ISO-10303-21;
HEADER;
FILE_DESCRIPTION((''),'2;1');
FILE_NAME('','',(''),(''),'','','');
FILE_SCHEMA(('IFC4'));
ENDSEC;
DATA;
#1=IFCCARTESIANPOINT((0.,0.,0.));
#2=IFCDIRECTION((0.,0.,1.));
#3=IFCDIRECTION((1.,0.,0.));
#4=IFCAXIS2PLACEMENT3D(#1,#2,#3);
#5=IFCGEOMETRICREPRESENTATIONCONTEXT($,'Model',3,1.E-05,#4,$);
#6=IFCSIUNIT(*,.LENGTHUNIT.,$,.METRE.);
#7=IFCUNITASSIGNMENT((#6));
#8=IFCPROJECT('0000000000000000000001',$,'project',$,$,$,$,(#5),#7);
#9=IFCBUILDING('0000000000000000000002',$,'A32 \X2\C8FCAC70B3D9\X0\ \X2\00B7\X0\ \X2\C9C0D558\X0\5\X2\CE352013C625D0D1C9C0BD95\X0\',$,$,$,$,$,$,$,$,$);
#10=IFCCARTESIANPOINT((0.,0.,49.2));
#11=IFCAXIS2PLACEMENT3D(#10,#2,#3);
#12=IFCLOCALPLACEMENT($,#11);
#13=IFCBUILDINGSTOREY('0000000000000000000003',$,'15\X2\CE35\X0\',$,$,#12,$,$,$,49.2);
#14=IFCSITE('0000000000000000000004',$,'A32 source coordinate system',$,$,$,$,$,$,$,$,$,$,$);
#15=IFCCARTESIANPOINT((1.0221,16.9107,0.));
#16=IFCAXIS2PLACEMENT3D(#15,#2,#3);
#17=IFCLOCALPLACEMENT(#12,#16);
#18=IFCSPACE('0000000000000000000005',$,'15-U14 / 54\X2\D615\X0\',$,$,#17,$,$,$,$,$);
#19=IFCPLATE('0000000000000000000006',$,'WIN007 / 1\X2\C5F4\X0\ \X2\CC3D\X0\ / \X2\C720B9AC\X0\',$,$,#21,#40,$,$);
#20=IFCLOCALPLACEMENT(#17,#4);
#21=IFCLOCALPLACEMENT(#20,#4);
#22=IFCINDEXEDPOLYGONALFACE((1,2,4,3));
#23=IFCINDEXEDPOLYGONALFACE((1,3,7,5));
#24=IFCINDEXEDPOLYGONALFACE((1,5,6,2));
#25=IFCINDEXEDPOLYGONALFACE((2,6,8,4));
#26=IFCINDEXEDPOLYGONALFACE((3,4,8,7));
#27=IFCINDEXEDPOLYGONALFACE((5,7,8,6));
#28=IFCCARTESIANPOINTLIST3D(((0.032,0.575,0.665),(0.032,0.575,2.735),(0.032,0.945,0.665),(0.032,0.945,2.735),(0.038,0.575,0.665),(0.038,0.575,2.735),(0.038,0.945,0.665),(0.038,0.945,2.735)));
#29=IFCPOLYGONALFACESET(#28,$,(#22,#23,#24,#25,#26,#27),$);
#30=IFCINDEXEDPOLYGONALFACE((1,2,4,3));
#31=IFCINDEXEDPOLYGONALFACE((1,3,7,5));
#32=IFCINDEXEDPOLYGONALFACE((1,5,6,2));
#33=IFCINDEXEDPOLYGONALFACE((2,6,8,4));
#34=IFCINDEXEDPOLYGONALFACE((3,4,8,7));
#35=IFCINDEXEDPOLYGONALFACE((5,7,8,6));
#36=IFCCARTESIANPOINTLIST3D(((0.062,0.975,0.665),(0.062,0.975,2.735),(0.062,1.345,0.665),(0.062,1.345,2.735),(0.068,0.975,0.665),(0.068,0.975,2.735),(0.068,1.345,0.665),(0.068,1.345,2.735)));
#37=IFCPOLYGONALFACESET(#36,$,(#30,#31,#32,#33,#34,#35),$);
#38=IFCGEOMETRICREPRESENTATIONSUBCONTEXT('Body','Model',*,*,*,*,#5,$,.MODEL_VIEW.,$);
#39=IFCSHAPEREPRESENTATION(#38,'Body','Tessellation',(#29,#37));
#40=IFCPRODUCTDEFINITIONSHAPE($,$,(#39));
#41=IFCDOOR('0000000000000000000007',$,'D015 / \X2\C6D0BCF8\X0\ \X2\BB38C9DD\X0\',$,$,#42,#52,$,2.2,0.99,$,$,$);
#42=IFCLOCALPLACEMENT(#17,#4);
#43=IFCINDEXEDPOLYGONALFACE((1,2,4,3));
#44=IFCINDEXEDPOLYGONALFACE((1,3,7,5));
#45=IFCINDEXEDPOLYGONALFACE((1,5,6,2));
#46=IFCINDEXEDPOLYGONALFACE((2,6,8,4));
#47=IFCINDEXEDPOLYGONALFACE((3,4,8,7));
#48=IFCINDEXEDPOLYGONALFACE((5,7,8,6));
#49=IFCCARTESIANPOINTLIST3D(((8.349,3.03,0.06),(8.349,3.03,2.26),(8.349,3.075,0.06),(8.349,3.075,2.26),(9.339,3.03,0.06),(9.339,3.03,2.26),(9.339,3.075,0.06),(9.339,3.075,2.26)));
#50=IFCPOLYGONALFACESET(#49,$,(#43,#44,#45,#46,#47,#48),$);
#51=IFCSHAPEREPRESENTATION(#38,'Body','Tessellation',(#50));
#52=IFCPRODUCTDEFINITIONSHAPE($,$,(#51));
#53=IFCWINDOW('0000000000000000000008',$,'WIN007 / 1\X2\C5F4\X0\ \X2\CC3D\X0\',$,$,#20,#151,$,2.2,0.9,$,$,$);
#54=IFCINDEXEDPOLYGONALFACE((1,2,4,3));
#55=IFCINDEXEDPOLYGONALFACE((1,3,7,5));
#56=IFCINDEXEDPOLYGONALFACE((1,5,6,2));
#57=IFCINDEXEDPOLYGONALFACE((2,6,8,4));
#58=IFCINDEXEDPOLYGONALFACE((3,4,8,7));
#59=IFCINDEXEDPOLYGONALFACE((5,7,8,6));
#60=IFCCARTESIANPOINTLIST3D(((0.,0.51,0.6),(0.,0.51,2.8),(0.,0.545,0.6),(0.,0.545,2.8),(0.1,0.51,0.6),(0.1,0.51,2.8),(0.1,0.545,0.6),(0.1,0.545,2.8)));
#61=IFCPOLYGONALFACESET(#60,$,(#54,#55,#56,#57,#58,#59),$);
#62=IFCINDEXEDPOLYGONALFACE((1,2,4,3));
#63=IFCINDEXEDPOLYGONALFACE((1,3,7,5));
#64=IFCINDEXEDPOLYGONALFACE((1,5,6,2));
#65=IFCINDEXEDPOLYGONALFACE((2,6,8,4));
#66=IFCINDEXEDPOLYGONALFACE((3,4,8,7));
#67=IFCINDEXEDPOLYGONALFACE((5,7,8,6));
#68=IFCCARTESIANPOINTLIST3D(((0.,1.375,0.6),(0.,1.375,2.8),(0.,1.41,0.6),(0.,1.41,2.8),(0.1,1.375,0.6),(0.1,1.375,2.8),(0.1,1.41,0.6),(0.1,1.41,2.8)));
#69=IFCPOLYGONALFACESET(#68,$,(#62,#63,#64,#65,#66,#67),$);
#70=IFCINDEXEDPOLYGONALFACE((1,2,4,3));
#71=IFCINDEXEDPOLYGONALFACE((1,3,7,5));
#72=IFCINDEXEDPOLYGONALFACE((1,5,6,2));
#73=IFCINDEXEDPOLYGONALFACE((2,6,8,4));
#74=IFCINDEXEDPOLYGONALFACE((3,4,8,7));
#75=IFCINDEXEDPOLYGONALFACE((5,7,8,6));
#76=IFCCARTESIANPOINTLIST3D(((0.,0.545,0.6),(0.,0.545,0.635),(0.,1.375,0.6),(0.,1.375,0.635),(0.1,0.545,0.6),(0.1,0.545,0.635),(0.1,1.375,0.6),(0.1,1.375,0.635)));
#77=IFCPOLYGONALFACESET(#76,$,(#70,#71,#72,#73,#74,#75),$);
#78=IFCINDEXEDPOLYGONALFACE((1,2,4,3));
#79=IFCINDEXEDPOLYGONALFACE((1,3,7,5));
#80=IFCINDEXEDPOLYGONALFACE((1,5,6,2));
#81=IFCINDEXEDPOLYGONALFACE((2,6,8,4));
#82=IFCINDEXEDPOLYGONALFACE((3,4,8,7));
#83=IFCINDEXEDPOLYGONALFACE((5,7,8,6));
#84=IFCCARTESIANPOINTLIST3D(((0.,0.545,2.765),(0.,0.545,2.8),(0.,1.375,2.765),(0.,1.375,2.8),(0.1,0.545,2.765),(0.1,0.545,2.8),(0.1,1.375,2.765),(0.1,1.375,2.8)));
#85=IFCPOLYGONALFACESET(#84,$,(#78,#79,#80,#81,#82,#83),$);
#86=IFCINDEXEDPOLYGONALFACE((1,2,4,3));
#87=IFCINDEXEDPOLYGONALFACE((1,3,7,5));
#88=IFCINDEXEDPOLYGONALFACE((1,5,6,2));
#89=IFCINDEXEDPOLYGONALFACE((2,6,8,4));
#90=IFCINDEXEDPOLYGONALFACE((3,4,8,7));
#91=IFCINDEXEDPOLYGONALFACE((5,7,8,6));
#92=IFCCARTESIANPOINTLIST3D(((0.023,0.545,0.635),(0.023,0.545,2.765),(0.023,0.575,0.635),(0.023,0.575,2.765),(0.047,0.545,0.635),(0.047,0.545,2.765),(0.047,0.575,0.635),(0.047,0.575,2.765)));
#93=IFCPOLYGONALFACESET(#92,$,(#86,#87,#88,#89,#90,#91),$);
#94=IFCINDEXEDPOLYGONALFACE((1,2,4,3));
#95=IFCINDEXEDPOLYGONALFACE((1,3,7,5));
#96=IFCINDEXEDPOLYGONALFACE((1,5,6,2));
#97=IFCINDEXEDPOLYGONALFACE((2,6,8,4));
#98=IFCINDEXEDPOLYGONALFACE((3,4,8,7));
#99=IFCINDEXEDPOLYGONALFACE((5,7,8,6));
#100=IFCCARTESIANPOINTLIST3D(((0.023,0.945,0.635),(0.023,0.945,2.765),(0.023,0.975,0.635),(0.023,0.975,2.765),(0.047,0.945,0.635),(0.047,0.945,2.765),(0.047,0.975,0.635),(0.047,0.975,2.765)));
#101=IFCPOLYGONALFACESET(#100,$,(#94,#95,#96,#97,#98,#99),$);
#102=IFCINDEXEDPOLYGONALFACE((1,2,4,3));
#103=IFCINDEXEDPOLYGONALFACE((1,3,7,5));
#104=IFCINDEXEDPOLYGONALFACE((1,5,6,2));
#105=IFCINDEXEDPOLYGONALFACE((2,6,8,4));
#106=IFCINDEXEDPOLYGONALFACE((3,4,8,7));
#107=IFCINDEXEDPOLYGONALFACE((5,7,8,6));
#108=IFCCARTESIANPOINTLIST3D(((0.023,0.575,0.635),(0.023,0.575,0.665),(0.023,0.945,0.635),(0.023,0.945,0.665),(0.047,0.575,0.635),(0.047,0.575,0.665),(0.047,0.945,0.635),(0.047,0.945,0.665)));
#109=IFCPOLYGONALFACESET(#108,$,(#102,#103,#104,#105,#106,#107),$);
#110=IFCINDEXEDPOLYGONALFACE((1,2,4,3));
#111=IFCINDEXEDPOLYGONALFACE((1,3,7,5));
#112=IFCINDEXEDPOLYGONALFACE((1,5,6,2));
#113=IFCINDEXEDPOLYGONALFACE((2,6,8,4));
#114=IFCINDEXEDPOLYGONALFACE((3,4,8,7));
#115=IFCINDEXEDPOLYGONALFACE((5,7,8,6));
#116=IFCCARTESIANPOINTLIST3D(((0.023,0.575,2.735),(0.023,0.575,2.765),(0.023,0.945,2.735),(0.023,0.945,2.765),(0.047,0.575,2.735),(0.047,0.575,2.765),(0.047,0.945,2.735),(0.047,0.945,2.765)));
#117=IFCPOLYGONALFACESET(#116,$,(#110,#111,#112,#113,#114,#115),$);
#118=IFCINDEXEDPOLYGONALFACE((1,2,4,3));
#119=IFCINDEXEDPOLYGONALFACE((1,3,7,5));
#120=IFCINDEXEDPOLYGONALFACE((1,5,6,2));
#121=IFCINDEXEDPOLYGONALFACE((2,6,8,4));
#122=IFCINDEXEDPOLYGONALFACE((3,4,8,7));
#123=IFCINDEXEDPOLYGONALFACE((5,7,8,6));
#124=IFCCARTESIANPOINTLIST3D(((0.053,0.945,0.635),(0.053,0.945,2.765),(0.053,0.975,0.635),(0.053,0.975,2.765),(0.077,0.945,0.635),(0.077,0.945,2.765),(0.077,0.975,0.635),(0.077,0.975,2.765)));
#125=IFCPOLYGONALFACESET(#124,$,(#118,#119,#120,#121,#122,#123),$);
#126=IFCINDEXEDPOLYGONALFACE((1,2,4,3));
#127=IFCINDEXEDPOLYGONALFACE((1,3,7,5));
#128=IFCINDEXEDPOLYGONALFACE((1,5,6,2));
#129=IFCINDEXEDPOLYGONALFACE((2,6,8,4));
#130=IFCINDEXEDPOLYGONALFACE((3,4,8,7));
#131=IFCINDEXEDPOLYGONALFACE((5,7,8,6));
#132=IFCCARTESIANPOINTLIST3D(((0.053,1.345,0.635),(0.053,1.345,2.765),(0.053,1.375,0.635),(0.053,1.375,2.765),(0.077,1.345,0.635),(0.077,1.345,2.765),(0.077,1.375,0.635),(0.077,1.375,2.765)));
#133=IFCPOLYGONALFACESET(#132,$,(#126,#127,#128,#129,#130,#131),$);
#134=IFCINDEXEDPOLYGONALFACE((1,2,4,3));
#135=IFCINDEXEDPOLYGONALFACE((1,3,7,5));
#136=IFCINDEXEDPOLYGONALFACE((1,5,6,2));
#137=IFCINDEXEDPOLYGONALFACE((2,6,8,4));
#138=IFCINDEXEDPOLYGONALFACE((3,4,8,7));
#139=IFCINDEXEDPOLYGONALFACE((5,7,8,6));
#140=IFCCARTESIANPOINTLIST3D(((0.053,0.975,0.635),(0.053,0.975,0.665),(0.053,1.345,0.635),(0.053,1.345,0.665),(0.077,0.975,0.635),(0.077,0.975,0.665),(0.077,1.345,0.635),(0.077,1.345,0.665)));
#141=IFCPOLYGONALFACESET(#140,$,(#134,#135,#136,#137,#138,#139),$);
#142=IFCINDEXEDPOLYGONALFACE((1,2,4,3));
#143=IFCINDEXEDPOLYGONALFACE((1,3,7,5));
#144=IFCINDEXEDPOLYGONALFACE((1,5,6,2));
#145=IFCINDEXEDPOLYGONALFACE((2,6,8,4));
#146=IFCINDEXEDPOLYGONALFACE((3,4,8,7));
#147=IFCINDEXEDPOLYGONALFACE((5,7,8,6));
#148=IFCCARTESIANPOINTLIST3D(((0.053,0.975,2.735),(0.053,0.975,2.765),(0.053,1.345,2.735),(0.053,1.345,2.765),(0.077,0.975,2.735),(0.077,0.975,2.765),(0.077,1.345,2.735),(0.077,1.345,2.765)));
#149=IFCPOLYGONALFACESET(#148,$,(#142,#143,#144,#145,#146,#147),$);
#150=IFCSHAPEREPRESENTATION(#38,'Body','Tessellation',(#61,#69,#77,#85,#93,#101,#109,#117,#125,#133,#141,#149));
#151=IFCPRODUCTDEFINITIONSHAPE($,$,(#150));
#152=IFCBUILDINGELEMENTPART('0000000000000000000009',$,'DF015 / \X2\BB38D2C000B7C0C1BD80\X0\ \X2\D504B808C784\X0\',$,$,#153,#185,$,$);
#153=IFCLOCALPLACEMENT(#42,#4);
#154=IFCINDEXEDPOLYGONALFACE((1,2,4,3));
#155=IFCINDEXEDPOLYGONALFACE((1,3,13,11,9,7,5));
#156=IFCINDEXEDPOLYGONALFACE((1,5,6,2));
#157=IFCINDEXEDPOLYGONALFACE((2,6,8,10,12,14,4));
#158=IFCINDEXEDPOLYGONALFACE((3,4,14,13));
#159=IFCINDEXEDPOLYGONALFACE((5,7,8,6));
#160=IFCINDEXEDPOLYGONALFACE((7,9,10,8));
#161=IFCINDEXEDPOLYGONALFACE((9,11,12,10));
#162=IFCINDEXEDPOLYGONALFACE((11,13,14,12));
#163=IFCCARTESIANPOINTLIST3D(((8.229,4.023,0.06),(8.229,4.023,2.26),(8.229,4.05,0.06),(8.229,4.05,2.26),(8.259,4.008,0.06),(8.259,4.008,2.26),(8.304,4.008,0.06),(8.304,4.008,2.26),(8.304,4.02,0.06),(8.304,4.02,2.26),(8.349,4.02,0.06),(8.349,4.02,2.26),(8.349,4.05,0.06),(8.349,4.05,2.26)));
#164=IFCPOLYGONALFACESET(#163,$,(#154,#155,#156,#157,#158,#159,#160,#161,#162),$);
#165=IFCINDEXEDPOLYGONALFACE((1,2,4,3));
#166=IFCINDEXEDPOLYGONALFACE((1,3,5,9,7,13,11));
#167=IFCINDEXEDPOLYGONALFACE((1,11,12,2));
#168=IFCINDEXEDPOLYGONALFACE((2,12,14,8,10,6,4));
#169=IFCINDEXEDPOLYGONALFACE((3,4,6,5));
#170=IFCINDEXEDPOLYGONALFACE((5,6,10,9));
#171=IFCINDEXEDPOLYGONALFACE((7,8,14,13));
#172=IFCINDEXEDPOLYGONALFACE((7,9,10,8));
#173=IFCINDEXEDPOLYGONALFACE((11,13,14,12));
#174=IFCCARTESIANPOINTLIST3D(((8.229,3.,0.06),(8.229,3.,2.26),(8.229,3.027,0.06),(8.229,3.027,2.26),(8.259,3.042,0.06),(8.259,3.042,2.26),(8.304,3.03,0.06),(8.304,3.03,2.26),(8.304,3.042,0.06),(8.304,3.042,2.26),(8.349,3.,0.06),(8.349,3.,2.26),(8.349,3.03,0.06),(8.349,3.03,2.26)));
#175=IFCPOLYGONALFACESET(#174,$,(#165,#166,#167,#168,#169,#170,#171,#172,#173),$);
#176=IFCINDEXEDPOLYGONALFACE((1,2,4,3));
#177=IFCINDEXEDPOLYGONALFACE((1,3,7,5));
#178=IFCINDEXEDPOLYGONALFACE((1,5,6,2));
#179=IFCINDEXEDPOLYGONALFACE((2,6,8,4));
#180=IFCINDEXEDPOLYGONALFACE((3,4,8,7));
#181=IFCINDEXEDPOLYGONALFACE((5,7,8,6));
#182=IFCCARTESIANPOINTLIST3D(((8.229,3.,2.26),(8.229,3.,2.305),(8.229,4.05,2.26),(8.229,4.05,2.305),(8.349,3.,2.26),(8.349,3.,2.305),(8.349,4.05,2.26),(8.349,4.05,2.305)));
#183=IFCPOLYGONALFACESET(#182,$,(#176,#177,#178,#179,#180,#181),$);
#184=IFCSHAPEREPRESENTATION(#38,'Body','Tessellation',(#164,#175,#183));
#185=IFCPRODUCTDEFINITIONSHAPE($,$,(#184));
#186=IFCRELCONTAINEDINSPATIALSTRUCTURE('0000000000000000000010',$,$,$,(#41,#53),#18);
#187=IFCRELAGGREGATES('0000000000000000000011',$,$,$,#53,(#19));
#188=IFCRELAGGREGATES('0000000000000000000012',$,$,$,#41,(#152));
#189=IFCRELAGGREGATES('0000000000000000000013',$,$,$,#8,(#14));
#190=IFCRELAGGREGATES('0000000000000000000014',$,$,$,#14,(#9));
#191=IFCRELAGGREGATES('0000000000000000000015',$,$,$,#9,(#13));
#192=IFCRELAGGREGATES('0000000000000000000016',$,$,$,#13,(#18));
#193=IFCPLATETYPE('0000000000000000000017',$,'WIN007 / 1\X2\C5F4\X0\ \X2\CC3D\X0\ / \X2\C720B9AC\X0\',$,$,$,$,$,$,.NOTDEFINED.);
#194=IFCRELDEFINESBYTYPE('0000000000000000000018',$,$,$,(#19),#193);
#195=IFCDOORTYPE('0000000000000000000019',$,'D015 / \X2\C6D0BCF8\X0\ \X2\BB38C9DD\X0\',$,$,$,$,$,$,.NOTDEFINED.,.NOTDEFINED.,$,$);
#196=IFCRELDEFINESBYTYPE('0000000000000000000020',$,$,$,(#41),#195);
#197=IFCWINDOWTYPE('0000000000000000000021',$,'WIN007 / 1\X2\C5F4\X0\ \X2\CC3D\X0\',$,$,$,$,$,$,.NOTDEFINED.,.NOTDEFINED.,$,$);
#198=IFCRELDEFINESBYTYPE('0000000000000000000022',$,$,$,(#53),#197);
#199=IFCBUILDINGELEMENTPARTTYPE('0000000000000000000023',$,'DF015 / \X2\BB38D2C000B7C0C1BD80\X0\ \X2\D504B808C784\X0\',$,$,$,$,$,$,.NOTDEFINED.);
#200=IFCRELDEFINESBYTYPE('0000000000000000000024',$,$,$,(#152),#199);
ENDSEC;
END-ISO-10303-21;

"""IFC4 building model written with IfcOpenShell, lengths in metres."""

from ifc_helpers import new_model, si_unit, frame, origin, origin_with_axes, place, context, subcontext, project, spatial, polyline, outline, extrude, source, transform, mapped, type_object, type_shapes, element, aggregate, save


model = new_model("IFC4")

# Units and contexts
model_context = context("Model", 3, precision=1e-05, world=origin_with_axes())
body_context = subcontext(model_context, "Body", "Model", "MODEL_VIEW")
ifc_project = project(units=[si_unit("LENGTHUNIT", "METRE")], contexts=[model_context])

# Plate
plate_type_1 = type_object("IfcPlateType", Name="WIN007 / 1열 창 / 유리", PredefinedType="NOTDEFINED")
shared_shape_1 = source(origin(), body_context, "Body", "SweptSolid", [
    extrude(outline(polyline([(0.032, 0.575), (0.032, 0.945), (0.038, 0.945), (0.038, 0.575), (0.032, 0.575)])), frame((0.0, 0.0, 0.665)), (0.0, 0.0, 1.0), 2.07),
    extrude(outline(polyline([(0.062, 0.975), (0.062, 1.345), (0.068, 1.345), (0.068, 0.975), (0.062, 0.975)])), frame((0.0, 0.0, 0.665)), (0.0, 0.0, 1.0), 2.07),
])
type_shapes(plate_type_1, [shared_shape_1])
storey_placement = place(None, frame((0.0, 0.0, 49.2), z_axis=(0.0, 0.0, 1.0), x_axis=(1.0, 0.0, 0.0)))
space_1_placement = place(storey_placement, frame((1.0221, 16.9107, 0.0), z_axis=(0.0, 0.0, 1.0), x_axis=(1.0, 0.0, 0.0)))
window_1_placement = place(space_1_placement, origin_with_axes())
plate_1_placement = place(window_1_placement, origin_with_axes())
plate_1 = element("IfcPlate", 1, at=plate_1_placement, type_object=plate_type_1, Name="WIN007 / 1열 창 / 유리", context=body_context, shape_type="MappedRepresentation", body=[
    mapped(shared_shape_1, transform((0.0, 0.0, 0.0), scale=1.0)),
])

# Site, building, storey, space
site = spatial("IfcSite", under=ifc_project, Name="A32 source coordinate system")
building = spatial("IfcBuilding", under=site, Name="A32 주거동 · 지하5층–옥탑지붕")
storey = spatial("IfcBuildingStorey", under=building, at=storey_placement, Name="15층", Elevation=49.2)
space_1 = spatial("IfcSpace", under=storey, at=space_1_placement, Name="15-U14 / 54형")

# Door
door_type_1 = type_object("IfcDoorType", Name="D015 / 원본 문짝", OperationType="NOTDEFINED", PredefinedType="NOTDEFINED")
shared_shape_2 = source(origin(), body_context, "Body", "SweptSolid", [
    extrude(outline(polyline([(9.339, 3.075), (9.339, 3.03), (8.349, 3.03), (8.349, 3.075), (9.339, 3.075)])), frame((0.0, 0.0, 0.06)), (0.0, 0.0, 1.0), 2.2),
])
type_shapes(door_type_1, [shared_shape_2])
door_1_placement = place(space_1_placement, origin_with_axes())
door_1 = element("IfcDoor", 2, at=door_1_placement, inside=space_1, type_object=door_type_1, Name="D015 / 원본 문짝", OverallHeight=2.2, OverallWidth=0.99, context=body_context, shape_type="MappedRepresentation", body=[
    mapped(shared_shape_2, transform((0.0, 0.0, 0.0), scale=1.0)),
])

# Window
window_type_1 = type_object("IfcWindowType", Name="WIN007 / 1열 창", PartitioningType="NOTDEFINED", PredefinedType="NOTDEFINED")
shared_shape_3 = source(origin(), body_context, "Body", "SweptSolid", [
    extrude(outline(polyline([(0.0, 0.51), (0.0, 0.545), (0.1, 0.545), (0.1, 0.51), (0.0, 0.51)])), frame((0.0, 0.0, 0.6)), (0.0, 0.0, 1.0), 2.2),
    extrude(outline(polyline([(0.0, 1.375), (0.0, 1.41), (0.1, 1.41), (0.1, 1.375), (0.0, 1.375)])), frame((0.0, 0.0, 0.6)), (0.0, 0.0, 1.0), 2.2),
    extrude(outline(polyline([(0.0, 0.545), (0.0, 1.375), (0.1, 1.375), (0.1, 0.545), (0.0, 0.545)])), frame((0.0, 0.0, 0.6)), (0.0, 0.0, 1.0), 0.035),
    extrude(outline(polyline([(0.0, 0.545), (0.0, 1.375), (0.1, 1.375), (0.1, 0.545), (0.0, 0.545)])), frame((0.0, 0.0, 2.765)), (0.0, 0.0, 1.0), 0.035),
    extrude(outline(polyline([(0.023, 0.545), (0.023, 0.575), (0.047, 0.575), (0.047, 0.545), (0.023, 0.545)])), frame((0.0, 0.0, 0.635)), (0.0, 0.0, 1.0), 2.13),
    extrude(outline(polyline([(0.023, 0.945), (0.023, 0.975), (0.047, 0.975), (0.047, 0.945), (0.023, 0.945)])), frame((0.0, 0.0, 0.635)), (0.0, 0.0, 1.0), 2.13),
    extrude(outline(polyline([(0.023, 0.575), (0.023, 0.945), (0.047, 0.945), (0.047, 0.575), (0.023, 0.575)])), frame((0.0, 0.0, 0.635)), (0.0, 0.0, 1.0), 0.03),
    extrude(outline(polyline([(0.023, 0.575), (0.023, 0.945), (0.047, 0.945), (0.047, 0.575), (0.023, 0.575)])), frame((0.0, 0.0, 2.735)), (0.0, 0.0, 1.0), 0.03),
    extrude(outline(polyline([(0.053, 0.945), (0.053, 0.975), (0.077, 0.975), (0.077, 0.945), (0.053, 0.945)])), frame((0.0, 0.0, 0.635)), (0.0, 0.0, 1.0), 2.13),
    extrude(outline(polyline([(0.053, 1.345), (0.053, 1.375), (0.077, 1.375), (0.077, 1.345), (0.053, 1.345)])), frame((0.0, 0.0, 0.635)), (0.0, 0.0, 1.0), 2.13),
    extrude(outline(polyline([(0.053, 0.975), (0.053, 1.345), (0.077, 1.345), (0.077, 0.975), (0.053, 0.975)])), frame((0.0, 0.0, 0.635)), (0.0, 0.0, 1.0), 0.03),
    extrude(outline(polyline([(0.053, 0.975), (0.053, 1.345), (0.077, 1.345), (0.077, 0.975), (0.053, 0.975)])), frame((0.0, 0.0, 2.735)), (0.0, 0.0, 1.0), 0.03),
])
type_shapes(window_type_1, [shared_shape_3])
window_1 = element("IfcWindow", 3, at=window_1_placement, inside=space_1, type_object=window_type_1, Name="WIN007 / 1열 창", OverallHeight=2.2, OverallWidth=0.9, context=body_context, shape_type="MappedRepresentation", body=[
    mapped(shared_shape_3, transform((0.0, 0.0, 0.0), scale=1.0)),
])
aggregate(window_1, [plate_1])

# Building element part
building_element_part_type_1 = type_object("IfcBuildingElementPartType", Name="DF015 / 문틀·상부 프레임", PredefinedType="NOTDEFINED")
shared_shape_4 = source(origin(), body_context, "Body", "SweptSolid", [
    extrude(outline(polyline([(8.349, 4.02), (8.304, 4.02), (8.304, 4.008), (8.259, 4.008), (8.229, 4.023), (8.229, 4.05), (8.349, 4.05), (8.349, 4.02)])), frame((0.0, 0.0, 0.06)), (0.0, 0.0, 1.0), 2.2),
    extrude(outline(polyline([(8.229, 3.0), (8.229, 3.027), (8.259, 3.042), (8.304, 3.042), (8.304, 3.03), (8.349, 3.03), (8.349, 3.0), (8.229, 3.0)])), frame((0.0, 0.0, 0.06)), (0.0, 0.0, 1.0), 2.2),
    extrude(outline(polyline([(8.229, 3.0), (8.229, 4.05), (8.349, 4.05), (8.349, 3.0), (8.229, 3.0)])), frame((0.0, 0.0, 2.26)), (0.0, 0.0, 1.0), 0.045),
])
type_shapes(building_element_part_type_1, [shared_shape_4])
building_element_part_1_placement = place(door_1_placement, origin_with_axes())
building_element_part_1 = element("IfcBuildingElementPart", 4, at=building_element_part_1_placement, type_object=building_element_part_type_1, Name="DF015 / 문틀·상부 프레임", context=body_context, shape_type="MappedRepresentation", body=[
    mapped(shared_shape_4, transform((0.0, 0.0, 0.0), scale=1.0)),
])
aggregate(door_1, [building_element_part_1])

save(model, "model.ifc")
